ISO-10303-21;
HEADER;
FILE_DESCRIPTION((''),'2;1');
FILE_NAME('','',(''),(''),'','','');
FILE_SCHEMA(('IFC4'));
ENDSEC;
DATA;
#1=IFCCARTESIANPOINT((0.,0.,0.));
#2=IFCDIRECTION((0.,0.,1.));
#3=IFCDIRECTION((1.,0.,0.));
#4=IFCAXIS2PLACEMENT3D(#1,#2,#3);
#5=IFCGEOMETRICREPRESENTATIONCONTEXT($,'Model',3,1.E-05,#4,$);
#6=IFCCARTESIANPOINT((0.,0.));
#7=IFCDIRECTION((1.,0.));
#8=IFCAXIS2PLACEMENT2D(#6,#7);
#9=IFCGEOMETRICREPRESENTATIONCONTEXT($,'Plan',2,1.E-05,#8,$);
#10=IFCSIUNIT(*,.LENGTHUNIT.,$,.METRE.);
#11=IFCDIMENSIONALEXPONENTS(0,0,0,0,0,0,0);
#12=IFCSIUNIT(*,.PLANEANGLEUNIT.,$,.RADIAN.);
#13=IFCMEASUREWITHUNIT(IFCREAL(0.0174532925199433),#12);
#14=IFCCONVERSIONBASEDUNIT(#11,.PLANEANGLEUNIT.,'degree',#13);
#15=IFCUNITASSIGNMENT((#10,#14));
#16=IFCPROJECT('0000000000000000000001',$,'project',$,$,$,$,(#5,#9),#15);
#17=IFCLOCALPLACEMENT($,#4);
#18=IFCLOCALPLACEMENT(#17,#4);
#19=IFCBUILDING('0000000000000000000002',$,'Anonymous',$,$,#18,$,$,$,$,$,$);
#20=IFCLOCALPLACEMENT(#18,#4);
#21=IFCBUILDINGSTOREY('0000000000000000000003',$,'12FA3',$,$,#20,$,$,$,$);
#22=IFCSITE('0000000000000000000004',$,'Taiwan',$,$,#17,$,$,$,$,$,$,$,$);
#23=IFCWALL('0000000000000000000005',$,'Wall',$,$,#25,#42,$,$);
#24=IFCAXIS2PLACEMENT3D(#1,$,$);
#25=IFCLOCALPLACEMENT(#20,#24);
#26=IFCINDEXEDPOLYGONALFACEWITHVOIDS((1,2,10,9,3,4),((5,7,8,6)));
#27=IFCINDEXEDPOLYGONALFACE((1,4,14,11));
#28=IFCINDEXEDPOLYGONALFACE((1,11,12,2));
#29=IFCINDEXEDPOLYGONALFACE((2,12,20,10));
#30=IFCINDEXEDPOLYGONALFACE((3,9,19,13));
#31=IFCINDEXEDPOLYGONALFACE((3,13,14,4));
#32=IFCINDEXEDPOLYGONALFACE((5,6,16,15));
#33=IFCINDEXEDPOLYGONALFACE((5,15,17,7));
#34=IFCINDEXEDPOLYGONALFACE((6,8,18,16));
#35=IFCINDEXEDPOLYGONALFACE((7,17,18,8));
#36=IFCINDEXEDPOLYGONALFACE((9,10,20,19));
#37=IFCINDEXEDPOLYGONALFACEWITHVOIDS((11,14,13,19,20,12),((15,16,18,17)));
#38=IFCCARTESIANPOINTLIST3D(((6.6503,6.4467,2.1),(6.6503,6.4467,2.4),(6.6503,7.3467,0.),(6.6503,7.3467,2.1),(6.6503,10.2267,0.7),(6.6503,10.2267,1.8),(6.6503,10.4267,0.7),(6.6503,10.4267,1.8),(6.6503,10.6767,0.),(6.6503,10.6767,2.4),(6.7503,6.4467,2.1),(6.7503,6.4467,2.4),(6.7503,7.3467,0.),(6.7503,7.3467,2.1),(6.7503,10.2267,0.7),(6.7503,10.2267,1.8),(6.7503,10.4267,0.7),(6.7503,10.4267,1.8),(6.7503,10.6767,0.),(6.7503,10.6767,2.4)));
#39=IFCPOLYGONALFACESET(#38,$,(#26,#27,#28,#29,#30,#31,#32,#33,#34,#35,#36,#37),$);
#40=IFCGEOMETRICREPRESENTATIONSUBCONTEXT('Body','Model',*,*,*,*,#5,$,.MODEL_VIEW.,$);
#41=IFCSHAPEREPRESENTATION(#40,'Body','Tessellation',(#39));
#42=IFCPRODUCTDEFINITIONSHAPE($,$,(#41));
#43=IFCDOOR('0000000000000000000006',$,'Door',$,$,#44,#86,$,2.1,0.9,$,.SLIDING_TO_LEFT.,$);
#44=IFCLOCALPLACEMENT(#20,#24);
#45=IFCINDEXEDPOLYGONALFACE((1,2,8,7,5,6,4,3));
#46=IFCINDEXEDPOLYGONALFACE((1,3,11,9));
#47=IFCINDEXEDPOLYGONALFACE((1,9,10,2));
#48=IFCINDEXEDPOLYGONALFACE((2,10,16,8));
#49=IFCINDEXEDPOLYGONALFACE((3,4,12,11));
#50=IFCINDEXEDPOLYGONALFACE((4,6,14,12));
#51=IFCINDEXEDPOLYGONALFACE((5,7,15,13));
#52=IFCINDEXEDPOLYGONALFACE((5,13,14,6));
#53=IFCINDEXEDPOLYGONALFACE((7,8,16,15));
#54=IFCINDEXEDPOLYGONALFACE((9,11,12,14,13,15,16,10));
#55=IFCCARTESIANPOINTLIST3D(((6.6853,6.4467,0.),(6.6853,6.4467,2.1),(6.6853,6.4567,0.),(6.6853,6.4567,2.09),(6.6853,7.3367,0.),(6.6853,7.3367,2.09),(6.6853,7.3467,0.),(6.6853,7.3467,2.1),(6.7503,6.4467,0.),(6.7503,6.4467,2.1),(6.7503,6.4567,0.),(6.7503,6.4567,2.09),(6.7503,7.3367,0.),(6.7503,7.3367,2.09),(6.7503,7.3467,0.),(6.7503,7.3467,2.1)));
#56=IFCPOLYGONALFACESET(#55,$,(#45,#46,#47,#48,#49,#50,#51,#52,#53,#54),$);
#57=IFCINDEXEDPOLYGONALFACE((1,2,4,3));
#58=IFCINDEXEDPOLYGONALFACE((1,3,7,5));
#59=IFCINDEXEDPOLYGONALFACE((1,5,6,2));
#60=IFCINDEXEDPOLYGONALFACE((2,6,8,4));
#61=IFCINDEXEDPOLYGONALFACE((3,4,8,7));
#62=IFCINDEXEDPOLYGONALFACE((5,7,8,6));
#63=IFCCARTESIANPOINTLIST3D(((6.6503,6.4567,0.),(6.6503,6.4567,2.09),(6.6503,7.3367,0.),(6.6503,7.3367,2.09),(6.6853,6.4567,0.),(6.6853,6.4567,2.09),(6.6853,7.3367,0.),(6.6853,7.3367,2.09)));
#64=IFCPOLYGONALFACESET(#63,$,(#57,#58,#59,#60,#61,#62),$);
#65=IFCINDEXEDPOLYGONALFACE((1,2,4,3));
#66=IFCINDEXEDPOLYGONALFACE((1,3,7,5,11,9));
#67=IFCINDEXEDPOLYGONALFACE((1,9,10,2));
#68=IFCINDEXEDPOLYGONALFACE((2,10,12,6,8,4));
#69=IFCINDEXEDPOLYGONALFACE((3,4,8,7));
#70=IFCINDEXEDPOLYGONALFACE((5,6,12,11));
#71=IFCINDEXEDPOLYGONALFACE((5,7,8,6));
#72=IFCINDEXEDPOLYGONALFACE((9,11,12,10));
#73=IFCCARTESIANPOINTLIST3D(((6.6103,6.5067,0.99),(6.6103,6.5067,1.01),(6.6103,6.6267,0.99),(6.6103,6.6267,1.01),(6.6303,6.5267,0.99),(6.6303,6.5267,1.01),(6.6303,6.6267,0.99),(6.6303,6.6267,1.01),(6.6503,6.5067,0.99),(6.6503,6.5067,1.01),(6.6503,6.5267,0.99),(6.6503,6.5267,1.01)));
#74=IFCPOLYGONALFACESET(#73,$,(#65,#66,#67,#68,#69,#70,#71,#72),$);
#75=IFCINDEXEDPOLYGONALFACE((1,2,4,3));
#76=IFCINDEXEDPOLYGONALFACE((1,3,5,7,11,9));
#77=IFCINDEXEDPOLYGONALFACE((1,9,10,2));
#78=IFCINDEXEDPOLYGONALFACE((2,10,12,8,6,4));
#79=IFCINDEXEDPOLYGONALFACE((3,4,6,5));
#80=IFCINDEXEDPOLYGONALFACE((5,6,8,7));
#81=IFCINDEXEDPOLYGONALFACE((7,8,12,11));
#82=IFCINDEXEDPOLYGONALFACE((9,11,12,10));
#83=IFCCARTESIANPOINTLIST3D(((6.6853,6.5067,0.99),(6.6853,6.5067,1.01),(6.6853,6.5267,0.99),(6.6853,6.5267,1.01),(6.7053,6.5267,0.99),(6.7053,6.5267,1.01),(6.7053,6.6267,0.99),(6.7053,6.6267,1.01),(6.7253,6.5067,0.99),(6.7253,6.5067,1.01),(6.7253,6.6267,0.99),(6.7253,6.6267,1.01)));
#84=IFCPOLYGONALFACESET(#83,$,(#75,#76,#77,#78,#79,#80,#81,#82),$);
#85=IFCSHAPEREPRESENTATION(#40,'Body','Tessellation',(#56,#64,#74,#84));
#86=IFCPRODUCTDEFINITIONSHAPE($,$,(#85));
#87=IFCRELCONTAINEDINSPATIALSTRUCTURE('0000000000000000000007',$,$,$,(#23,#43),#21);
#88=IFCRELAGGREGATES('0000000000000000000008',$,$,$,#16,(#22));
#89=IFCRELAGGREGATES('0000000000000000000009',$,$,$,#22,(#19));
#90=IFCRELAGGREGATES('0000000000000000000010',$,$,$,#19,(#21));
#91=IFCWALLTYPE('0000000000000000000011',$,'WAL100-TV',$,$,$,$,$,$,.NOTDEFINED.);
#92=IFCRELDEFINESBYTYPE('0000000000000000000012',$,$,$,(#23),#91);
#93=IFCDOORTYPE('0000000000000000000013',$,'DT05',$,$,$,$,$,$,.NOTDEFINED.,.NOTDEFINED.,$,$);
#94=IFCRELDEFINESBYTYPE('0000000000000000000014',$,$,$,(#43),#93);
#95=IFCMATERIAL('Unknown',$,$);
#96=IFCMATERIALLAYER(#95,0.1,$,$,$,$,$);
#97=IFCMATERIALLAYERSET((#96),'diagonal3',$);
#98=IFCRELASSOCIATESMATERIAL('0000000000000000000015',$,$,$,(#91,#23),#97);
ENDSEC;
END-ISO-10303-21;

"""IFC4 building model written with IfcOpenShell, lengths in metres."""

from ifc_helpers import new_model, entity, si_unit, converted_unit, frame, origin_with_axes, origin_2d_with_axis, place, context, subcontext, project, spatial, line, indexed_curve, outline, extrude, shape, source, transform, mapped, material, layer, layer_set, layer_usage, type_object, type_shapes, element, fill, save


model = new_model("IFC4")

# Units and contexts
model_context = context("Model", 3, precision=1e-05, world=origin_with_axes())
plan_context = context("Plan", 2, precision=1e-05, world=origin_2d_with_axis())
body_context_1 = subcontext(model_context, "Body", "Model", "MODEL_VIEW")
body_context_2 = subcontext(plan_context, "Body", "Plan", "PLAN_VIEW")
ifc_project = project(units=[si_unit("LENGTHUNIT", "METRE"), converted_unit("PLANEANGLEUNIT", "degree", entity("IfcReal", 0.0174532925199433), si_unit("PLANEANGLEUNIT", "RADIAN"), dimensions=[0, 0, 0, 0, 0, 0, 0])], contexts=[model_context, plan_context])

# Site, building, storey
site_placement = place(None, origin_with_axes())
site = spatial("IfcSite", under=ifc_project, at=site_placement, Name="Taiwan")
building_placement = place(site_placement, origin_with_axes())
building = spatial("IfcBuilding", under=site, at=building_placement, Name="Anonymous")
storey_placement = place(building_placement, origin_with_axes())
storey = spatial("IfcBuildingStorey", under=building, at=storey_placement, Name="12FA3")

# Shared definitions
ifc_material = material(Name="Unknown")

# Wall, openings, door
ifc_layer_1 = layer(ifc_material, 0.1)
ifc_layer_set_1 = layer_set([ifc_layer_1], Name="diagonal3")
ifc_layer_usage_1 = layer_usage(ifc_layer_set_1, "AXIS2", "POSITIVE", 0.0)
wall_type_1 = type_object("IfcWallType", Name="WAL100-TV", PredefinedType="NOTDEFINED", material=ifc_layer_set_1)
wall_1_placement = place(storey_placement, frame((6.6503, 10.6767, 0.0), z_axis=(0.0, 0.0, 1.0), x_axis=(0.0, -1.0, 0.0)))
wall_1 = element("IfcWall", 1, at=wall_1_placement, inside=storey, type_object=wall_type_1, material=ifc_layer_usage_1, Name="Wall", context=body_context_1, shape_type="SweptSolid", body=[
    extrude(outline(indexed_curve([(0.0, 0.0), (0.0, 0.1), (4.23, 0.1), (4.23, 0.0)], segments=[line(1, 2, 3, 4, 1)])), origin_with_axes(), (0.0, 0.0, 1.0), 2.4),
])
shared_shape_1 = source(origin_with_axes(), body_context_1, "Body", "SweptSolid", [
    extrude(outline(indexed_curve([(0.0, 0.0), (0.9, 0.0), (0.9, 2.1), (0.0, 2.1)], segments=[line(1, 2, 3, 4, 1)])), frame((0.0, -0.6, 0.0), z_axis=(0.0, -1.0, 0.0), x_axis=(1.0, 0.0, 0.0)), (0.0, 0.0, -1.0), 1.2),
])
opening_1_placement = place(wall_1_placement, frame((3.33, 0.0, 0.0), z_axis=(0.0, 0.0, 1.0), x_axis=(1.0, 0.0, 0.0)))
opening_1 = element("IfcOpeningElement", 2, at=opening_1_placement, cuts=wall_1, PredefinedType="OPENING", context=body_context_1, shape_type="MappedRepresentation", body=[
    mapped(shared_shape_1, transform((0.0, 0.0, 0.0), x_axis=(1.0, 0.0, 0.0), y_axis=(0.0, 1.0, 0.0), z_axis=(0.0, 0.0, 1.0), scale=1.0)),
])
opening_2_placement = place(wall_1_placement, frame((0.45, 0.0, 0.7), z_axis=(0.0, 0.0, 1.0), x_axis=(0.0, 1.0, 0.0)))
element("IfcOpeningElement", 3, at=opening_2_placement, cuts=wall_1, PredefinedType="OPENING", context=body_context_1, shape_type="SweptSolid", body=[
    extrude(outline(indexed_curve([(0.0, 0.0), (0.5, 0.0), (0.5, 0.2), (0.0, 0.2), (0.0, 0.0)])), origin_with_axes(), (0.0, 0.0, 1.0), 1.1),
])
door_type_1 = type_object("IfcDoorType", Name="DT05", OperationType="NOTDEFINED", PredefinedType="NOTDEFINED")
shared_shape_2 = source(origin_with_axes(), body_context_1, "Body", "SweptSolid", [
    extrude(outline(indexed_curve([(0.0, 0.0), (0.0, 2.1), (0.9, 2.1), (0.9, 0.0), (0.89, 0.0), (0.89, 2.09), (0.01, 2.09), (0.01, 0.0)], segments=[line(1, 2, 3, 4, 5, 6, 7, 8, 1)])), frame((0.0, 0.035, 0.0), z_axis=(0.0, -1.0, 0.0), x_axis=(1.0, 0.0, 0.0)), (0.0, 0.0, -1.0), 0.065),
    extrude(outline(indexed_curve([(0.0, 0.0), (0.88, 0.0), (0.88, 0.035), (0.0, 0.035)], segments=[line(1, 2, 3, 4, 1)])), frame((0.01, 0.0, 0.0), z_axis=(0.0, 0.0, 1.0), x_axis=(1.0, 0.0, 0.0)), (0.0, 0.0, 1.0), 2.09),
    extrude(outline(indexed_curve([(0.0, 0.0), (0.0, -0.04), (-0.12, -0.04), (-0.12, -0.02), (-0.02, -0.02), (-0.02, 0.0)], segments=[line(1, 2, 3, 4, 5, 6, 1)])), frame((0.84, 0.0, 0.99), z_axis=(0.0, 0.0, 1.0), x_axis=(1.0, 0.0, 0.0)), (0.0, 0.0, 1.0), 0.02),
    extrude(outline(indexed_curve([(0.0, 0.0), (0.0, 0.04), (-0.12, 0.04), (-0.12, 0.02), (-0.02, 0.02), (-0.02, 0.0)], segments=[line(1, 2, 3, 4, 5, 6, 1)])), frame((0.84, 0.035, 0.99), z_axis=(0.0, 0.0, 1.0), x_axis=(1.0, 0.0, 0.0)), (0.0, 0.0, 1.0), 0.02),
])
shared_shape_3 = source(origin_with_axes(), body_context_2, "Body", "Curve2D", [
    entity("IfcIndexedPolyCurve", entity("IfcCartesianPointList2D", [[0.0, 0.035], [0.01, 0.035], [0.01, 0.1], [0.0, 0.1]]), [entity("IfcLineIndex", [1, 2, 3, 4, 1])]),
    entity("IfcIndexedPolyCurve", entity("IfcCartesianPointList2D", [[0.9, 0.035], [0.89, 0.035], [0.89, 0.1], [0.9, 0.1]]), [entity("IfcLineIndex", [1, 2, 3, 4, 1])]),
    entity("IfcIndexedPolyCurve", entity("IfcCartesianPointList2D", [[-0.43, 0.0], [0.45, 0.0], [0.45, 0.035], [-0.43, 0.035]]), [entity("IfcLineIndex", [1, 2, 3, 4, 1])]),
])
type_shapes(door_type_1, [shared_shape_2, shared_shape_3])
door_1_placement = place(opening_1_placement, frame((0.0, 0.0, 0.0), z_axis=(0.0, 0.0, 1.0), x_axis=(1.0, 0.0, 0.0)))
door_1 = element("IfcDoor", 4, at=door_1_placement, inside=storey, type_object=door_type_1, Name="Door", OperationType="SLIDING_TO_LEFT", OverallHeight=2.1, OverallWidth=0.9, shapes=[
    shape(body_context_1, "Body", "MappedRepresentation", [mapped(shared_shape_2, transform((0.0, 0.0, 0.0), x_axis=(1.0, 0.0, 0.0), y_axis=(0.0, 1.0, 0.0), z_axis=(0.0, 0.0, 1.0), scale=1.0))]),
    shape(body_context_2, "Body", "MappedRepresentation", [mapped(shared_shape_3, transform((0.0, 0.0, 0.0), x_axis=(1.0, 0.0, 0.0), y_axis=(0.0, 1.0, 0.0), z_axis=(0.0, 0.0, 1.0), scale=1.0))]),
])
fill(opening_1, door_1)

save(model, "model.ifc")
